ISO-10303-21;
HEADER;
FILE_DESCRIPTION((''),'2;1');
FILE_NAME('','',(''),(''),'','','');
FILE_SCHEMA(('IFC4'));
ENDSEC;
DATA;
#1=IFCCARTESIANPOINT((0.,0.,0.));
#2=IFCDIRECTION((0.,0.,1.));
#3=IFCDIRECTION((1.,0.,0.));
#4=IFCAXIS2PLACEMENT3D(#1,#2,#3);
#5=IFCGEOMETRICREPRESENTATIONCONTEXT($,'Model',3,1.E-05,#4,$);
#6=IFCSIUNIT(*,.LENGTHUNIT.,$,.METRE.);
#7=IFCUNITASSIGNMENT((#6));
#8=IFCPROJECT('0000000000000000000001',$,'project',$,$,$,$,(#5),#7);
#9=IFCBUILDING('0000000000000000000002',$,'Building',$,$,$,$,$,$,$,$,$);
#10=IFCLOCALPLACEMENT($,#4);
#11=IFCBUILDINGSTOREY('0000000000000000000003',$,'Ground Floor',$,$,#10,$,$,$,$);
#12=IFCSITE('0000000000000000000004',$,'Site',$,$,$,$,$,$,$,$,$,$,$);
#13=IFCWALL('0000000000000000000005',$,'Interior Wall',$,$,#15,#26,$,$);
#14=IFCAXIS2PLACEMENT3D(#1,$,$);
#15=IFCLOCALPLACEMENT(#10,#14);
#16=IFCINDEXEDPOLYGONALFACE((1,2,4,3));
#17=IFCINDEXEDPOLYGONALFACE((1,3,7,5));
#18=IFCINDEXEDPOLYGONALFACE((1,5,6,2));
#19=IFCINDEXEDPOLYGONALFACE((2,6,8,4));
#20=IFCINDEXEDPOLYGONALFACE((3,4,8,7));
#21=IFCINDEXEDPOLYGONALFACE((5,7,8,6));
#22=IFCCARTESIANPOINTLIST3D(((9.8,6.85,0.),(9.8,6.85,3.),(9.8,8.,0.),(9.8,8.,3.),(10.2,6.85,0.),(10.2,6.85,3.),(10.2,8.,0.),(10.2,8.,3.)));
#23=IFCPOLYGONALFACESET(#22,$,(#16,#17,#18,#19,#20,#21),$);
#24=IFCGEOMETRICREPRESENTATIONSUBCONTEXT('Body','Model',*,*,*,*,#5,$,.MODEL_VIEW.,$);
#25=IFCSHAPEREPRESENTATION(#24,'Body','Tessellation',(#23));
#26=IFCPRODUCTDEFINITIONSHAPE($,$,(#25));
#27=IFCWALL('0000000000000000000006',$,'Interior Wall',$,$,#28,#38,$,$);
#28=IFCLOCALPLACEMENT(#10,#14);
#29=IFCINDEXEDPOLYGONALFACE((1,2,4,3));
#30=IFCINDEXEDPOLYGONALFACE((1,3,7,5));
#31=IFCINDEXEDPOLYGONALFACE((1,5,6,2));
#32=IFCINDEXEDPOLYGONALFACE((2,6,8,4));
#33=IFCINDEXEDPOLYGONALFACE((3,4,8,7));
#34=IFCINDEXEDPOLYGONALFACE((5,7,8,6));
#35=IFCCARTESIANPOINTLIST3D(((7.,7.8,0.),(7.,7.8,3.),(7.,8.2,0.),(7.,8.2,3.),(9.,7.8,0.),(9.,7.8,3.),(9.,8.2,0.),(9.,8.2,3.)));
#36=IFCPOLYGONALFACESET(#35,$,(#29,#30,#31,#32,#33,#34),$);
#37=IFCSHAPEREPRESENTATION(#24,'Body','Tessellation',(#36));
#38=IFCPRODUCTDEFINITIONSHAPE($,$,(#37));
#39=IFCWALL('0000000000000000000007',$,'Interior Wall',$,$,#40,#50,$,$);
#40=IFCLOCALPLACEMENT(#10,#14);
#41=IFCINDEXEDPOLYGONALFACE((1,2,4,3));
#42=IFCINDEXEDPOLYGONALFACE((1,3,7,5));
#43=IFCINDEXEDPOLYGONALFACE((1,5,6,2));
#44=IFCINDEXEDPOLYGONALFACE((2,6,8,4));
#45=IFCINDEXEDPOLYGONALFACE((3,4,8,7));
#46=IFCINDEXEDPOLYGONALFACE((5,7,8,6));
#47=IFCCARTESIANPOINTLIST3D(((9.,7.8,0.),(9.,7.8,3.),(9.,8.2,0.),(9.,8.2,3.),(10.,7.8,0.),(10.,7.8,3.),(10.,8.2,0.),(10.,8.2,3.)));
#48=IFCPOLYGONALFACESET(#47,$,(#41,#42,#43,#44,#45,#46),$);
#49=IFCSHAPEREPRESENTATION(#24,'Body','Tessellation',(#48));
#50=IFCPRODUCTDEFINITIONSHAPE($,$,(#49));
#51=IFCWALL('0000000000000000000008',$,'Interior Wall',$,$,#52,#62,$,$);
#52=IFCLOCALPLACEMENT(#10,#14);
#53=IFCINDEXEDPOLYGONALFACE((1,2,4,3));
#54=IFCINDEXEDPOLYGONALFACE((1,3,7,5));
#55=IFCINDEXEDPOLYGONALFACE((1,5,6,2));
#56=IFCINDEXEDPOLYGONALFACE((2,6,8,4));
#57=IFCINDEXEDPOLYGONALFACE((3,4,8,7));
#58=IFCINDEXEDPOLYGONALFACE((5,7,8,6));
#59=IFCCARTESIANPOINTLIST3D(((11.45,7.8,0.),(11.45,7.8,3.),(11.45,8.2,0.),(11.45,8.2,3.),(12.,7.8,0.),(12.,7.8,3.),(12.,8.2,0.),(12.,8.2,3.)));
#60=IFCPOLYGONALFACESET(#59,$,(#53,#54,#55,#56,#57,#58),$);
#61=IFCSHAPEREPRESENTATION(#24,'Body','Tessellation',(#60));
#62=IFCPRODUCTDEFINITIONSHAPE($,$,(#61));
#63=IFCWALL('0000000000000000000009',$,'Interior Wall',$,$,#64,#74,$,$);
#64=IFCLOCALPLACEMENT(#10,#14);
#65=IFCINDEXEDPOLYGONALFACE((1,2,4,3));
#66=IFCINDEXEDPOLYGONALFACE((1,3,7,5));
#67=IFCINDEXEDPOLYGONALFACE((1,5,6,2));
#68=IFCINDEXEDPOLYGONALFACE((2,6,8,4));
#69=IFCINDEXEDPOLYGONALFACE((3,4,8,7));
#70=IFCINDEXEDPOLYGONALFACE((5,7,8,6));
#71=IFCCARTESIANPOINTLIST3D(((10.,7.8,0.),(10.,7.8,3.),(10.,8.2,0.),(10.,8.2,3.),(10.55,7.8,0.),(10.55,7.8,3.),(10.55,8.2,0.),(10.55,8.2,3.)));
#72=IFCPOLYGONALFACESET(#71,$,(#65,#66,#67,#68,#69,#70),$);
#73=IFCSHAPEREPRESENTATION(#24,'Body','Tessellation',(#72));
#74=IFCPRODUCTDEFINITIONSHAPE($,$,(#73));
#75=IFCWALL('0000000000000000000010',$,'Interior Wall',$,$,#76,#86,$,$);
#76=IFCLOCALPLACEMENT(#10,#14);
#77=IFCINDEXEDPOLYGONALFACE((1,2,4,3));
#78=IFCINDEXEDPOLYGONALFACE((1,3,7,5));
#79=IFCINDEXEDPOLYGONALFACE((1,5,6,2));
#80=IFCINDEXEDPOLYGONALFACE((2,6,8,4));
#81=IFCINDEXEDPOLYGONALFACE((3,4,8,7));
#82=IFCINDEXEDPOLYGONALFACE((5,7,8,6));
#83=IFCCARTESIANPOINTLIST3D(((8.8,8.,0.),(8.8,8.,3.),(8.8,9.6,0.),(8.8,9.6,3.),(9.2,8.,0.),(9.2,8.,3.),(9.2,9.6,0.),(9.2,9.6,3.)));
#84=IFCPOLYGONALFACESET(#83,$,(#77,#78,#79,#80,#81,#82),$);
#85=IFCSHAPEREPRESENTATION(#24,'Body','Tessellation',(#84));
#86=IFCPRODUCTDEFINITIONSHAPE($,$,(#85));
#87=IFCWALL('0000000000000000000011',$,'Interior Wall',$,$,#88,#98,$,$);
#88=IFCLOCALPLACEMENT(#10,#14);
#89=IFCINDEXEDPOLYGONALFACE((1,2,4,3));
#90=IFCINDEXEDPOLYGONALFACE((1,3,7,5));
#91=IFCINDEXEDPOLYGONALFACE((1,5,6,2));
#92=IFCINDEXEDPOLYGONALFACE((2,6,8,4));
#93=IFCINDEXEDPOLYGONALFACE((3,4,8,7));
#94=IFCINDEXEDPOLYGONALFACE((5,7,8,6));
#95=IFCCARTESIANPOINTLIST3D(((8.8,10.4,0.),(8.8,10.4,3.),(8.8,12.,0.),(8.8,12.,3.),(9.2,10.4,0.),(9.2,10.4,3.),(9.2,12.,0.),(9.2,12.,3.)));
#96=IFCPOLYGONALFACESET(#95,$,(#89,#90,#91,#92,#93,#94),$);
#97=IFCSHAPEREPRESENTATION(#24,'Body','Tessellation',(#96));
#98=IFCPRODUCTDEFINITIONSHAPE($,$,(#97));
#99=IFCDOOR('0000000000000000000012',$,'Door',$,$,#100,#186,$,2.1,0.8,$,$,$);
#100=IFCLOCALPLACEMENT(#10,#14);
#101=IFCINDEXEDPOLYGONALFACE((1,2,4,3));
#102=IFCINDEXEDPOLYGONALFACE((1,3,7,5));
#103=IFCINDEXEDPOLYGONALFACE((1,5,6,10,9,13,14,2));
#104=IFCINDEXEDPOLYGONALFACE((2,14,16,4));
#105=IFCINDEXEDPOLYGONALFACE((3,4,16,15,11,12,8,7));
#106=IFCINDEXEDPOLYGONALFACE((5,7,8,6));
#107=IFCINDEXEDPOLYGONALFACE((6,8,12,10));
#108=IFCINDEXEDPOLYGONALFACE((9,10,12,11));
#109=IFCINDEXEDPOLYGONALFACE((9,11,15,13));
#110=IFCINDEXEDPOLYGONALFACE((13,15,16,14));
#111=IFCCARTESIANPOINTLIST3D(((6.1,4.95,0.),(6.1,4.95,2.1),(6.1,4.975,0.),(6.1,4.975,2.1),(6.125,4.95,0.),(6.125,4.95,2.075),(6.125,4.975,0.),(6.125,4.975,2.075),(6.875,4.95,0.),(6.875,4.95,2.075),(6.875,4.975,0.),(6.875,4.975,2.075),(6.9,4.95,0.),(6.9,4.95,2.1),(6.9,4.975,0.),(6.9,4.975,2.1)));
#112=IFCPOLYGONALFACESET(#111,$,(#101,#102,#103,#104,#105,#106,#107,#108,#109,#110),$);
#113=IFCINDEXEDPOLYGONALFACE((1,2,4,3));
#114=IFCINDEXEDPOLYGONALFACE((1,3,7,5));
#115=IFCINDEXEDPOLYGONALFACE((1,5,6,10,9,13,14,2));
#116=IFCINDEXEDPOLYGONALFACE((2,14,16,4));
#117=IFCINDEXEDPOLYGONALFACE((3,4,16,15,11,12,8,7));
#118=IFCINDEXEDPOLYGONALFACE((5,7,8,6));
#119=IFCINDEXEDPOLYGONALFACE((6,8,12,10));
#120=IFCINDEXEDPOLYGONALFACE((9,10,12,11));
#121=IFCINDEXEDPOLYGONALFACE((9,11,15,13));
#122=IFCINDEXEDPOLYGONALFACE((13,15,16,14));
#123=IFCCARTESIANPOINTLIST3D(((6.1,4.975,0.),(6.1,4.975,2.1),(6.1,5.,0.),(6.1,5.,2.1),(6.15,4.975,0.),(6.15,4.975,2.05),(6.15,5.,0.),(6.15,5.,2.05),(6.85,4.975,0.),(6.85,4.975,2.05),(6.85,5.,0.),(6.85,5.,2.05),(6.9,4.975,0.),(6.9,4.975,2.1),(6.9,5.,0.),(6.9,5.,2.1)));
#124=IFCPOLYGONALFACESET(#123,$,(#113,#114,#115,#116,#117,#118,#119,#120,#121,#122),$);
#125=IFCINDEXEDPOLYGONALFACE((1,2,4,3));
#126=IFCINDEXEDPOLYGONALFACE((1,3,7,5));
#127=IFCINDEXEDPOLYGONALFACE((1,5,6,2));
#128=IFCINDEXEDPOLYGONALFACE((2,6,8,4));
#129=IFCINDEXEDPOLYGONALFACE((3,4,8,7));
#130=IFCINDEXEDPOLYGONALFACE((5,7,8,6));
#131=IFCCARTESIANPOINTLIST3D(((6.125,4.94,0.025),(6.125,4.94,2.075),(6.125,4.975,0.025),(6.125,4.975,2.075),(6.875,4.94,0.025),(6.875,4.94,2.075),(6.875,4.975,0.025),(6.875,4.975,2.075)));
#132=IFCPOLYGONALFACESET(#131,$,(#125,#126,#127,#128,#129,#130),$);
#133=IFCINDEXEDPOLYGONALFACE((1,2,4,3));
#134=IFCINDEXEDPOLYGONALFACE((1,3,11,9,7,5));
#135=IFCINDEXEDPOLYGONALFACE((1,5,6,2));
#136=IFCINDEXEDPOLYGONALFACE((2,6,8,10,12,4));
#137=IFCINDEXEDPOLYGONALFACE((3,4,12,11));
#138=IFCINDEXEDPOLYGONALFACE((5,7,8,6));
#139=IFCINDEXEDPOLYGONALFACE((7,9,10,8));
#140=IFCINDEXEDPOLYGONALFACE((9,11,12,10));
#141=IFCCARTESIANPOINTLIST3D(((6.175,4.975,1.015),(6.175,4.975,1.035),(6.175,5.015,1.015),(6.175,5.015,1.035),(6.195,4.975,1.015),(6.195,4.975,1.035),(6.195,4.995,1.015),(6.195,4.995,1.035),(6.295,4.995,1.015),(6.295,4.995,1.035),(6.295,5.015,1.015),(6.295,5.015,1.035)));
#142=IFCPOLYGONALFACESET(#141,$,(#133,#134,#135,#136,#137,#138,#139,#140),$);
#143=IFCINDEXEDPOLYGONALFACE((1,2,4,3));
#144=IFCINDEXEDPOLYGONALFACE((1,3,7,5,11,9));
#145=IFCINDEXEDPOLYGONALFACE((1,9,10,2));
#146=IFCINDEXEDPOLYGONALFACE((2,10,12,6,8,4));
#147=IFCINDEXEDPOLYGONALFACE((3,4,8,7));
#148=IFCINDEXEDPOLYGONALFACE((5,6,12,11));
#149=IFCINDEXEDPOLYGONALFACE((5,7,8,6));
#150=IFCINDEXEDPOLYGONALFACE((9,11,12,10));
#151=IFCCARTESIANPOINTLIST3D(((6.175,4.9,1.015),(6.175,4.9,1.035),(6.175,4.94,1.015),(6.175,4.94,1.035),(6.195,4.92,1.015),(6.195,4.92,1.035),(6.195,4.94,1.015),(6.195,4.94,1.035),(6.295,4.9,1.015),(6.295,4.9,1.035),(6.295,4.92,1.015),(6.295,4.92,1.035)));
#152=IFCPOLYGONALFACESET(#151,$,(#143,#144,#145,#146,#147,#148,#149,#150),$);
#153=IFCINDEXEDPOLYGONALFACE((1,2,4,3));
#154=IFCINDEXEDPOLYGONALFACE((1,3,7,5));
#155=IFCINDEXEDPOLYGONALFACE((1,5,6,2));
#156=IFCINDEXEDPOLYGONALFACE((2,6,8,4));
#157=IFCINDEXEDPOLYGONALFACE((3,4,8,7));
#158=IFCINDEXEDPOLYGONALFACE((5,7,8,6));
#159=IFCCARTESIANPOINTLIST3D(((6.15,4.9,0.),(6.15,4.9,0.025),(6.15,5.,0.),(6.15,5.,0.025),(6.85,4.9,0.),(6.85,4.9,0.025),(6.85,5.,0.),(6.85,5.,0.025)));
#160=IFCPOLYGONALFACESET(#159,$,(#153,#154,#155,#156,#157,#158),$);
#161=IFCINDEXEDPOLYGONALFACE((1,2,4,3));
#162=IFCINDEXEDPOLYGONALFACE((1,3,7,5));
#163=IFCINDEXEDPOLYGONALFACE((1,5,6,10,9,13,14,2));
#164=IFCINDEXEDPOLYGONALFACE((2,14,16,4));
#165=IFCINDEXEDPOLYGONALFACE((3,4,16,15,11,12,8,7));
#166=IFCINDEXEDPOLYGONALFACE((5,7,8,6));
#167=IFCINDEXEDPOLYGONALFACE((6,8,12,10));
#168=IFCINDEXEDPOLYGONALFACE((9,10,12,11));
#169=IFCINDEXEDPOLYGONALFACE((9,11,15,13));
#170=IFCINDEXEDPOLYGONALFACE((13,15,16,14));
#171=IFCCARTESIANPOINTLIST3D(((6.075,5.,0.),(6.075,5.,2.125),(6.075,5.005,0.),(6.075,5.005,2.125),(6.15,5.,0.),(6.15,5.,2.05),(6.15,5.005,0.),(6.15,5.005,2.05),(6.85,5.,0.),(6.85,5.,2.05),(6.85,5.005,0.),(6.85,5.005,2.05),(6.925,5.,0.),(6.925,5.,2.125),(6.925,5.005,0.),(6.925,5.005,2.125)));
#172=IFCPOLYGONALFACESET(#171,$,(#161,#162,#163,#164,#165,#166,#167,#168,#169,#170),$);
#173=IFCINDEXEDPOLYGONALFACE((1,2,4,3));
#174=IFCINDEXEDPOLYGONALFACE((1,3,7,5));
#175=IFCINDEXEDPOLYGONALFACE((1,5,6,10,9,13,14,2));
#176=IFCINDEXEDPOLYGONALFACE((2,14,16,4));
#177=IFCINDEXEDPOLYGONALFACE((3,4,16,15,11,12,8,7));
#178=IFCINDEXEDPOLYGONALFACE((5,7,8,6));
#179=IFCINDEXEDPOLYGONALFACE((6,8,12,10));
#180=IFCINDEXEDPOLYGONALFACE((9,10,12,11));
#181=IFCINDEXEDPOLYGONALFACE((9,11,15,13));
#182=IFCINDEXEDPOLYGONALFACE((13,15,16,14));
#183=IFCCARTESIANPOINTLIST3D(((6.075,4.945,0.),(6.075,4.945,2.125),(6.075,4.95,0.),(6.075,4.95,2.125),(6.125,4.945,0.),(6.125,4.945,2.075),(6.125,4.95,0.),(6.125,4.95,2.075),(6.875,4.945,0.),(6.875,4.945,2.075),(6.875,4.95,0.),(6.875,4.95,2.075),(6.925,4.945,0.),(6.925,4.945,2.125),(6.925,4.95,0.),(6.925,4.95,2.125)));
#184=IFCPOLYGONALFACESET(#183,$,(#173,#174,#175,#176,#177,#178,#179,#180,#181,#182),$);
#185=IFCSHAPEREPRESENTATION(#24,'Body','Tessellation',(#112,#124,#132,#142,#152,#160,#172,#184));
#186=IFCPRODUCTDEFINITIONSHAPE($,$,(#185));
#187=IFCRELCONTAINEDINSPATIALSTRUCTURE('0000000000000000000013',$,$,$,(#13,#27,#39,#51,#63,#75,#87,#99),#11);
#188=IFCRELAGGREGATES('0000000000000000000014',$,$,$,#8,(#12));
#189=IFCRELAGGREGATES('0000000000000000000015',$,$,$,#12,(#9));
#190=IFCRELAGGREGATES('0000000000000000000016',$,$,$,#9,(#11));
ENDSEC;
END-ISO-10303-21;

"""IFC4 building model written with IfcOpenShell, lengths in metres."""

from ifc_helpers import new_model, si_unit, frame, origin_with_axes, place, context, subcontext, project, spatial, line, indexed_curve, outline, extrude, element, save


model = new_model("IFC4")

# Units and contexts
model_context = context("Model", 3, precision=1e-05, world=origin_with_axes())
body_context = subcontext(model_context, "Body", "Model", "MODEL_VIEW")
ifc_project = project(units=[si_unit("LENGTHUNIT", "METRE")], contexts=[model_context])

# Site, building, storey
site = spatial("IfcSite", under=ifc_project, Name="Site")
building = spatial("IfcBuilding", under=site, Name="Building")
storey_placement = place(None, origin_with_axes())
storey = spatial("IfcBuildingStorey", under=building, at=storey_placement, Name="Ground Floor")

# Walls
for number, where, z_axis, x_axis, name in (
    (1, (10.0, 6.85, 0.0), (0.0, 0.0, 1.0), (0.0, 1.0, 0.0), "Interior Wall"),
):
    element("IfcWall", number, at=place(storey_placement, frame(where, z_axis=z_axis, x_axis=x_axis)), inside=storey, Name=name, context=body_context, shape_type="SweptSolid", body=[
        extrude(outline(indexed_curve([(0.0, 0.0), (0.0, 0.4), (1.15, 0.4), (1.15, 0.0), (0.0, 0.0)], self_intersect=False)), frame((0.0, -0.2, 0.0), z_axis=(0.0, 0.0, 1.0), x_axis=(1.0, 0.0, 0.0)), (0.0, 0.0, 1.0), 3.0),
    ])
wall_1_placement = place(storey_placement, frame((9.0, 8.0, 0.0), z_axis=(0.0, 0.0, 1.0), x_axis=(-1.0, 0.0, 0.0)))
element("IfcWall", 2, at=wall_1_placement, inside=storey, Name="Interior Wall", context=body_context, shape_type="SweptSolid", body=[
    extrude(outline(indexed_curve([(0.0, 0.0), (0.0, 0.4), (2.0, 0.4), (2.0, 0.0), (0.0, 0.0)], self_intersect=False)), frame((0.0, -0.2, 0.0), z_axis=(0.0, 0.0, 1.0), x_axis=(1.0, 0.0, 0.0)), (0.0, 0.0, 1.0), 3.0),
])
wall_2_placement = place(storey_placement, frame((10.0, 8.0, 0.0), z_axis=(0.0, 0.0, 1.0), x_axis=(-1.0, 0.0, 0.0)))
element("IfcWall", 3, at=wall_2_placement, inside=storey, Name="Interior Wall", context=body_context, shape_type="SweptSolid", body=[
    extrude(outline(indexed_curve([(0.0, 0.0), (0.0, 0.4), (1.0, 0.4), (1.0, 0.0), (0.0, 0.0)], self_intersect=False)), frame((0.0, -0.2, 0.0), z_axis=(0.0, 0.0, 1.0), x_axis=(1.0, 0.0, 0.0)), (0.0, 0.0, 1.0), 3.0),
])
for number, where, z_axis, x_axis, name in (
    (4, (12.0, 8.0, 0.0), (0.0, 0.0, 1.0), (-1.0, 0.0, 0.0), "Interior Wall"),
    (5, (10.55, 8.0, 0.0), (0.0, 0.0, 1.0), (-1.0, 0.0, 0.0), "Interior Wall"),
):
    element("IfcWall", number, at=place(storey_placement, frame(where, z_axis=z_axis, x_axis=x_axis)), inside=storey, Name=name, context=body_context, shape_type="SweptSolid", body=[
        extrude(outline(indexed_curve([(0.0, 0.0), (0.0, 0.4), (0.55, 0.4), (0.55, 0.0), (0.0, 0.0)], self_intersect=False)), frame((0.0, -0.2, 0.0), z_axis=(0.0, 0.0, 1.0), x_axis=(1.0, 0.0, 0.0)), (0.0, 0.0, 1.0), 3.0),
    ])
for number, where, z_axis, x_axis, name in (
    (6, (9.0, 8.0, 0.0), (0.0, 0.0, 1.0), (0.0, 1.0, 0.0), "Interior Wall"),
    (7, (9.0, 10.4, 0.0), (0.0, 0.0, 1.0), (0.0, 1.0, 0.0), "Interior Wall"),
):
    element("IfcWall", number, at=place(storey_placement, frame(where, z_axis=z_axis, x_axis=x_axis)), inside=storey, Name=name, context=body_context, shape_type="SweptSolid", body=[
        extrude(outline(indexed_curve([(0.0, 0.0), (0.0, 0.4), (1.6, 0.4), (1.6, 0.0), (0.0, 0.0)], self_intersect=False)), frame((0.0, -0.2, 0.0), z_axis=(0.0, 0.0, 1.0), x_axis=(1.0, 0.0, 0.0)), (0.0, 0.0, 1.0), 3.0),
    ])

# Door
door_1_placement = place(storey_placement, frame((6.9, 5.0, 0.0), z_axis=(0.0, 0.0, 1.0), x_axis=(-1.0, 0.0, 0.0)))
element("IfcDoor", 8, at=door_1_placement, inside=storey, Name="Door", OverallHeight=2.1, OverallWidth=0.8, context=body_context, shape_type="SweptSolid", body=[
    extrude(outline(indexed_curve([(0.0, 0.0), (0.0, 2.1), (0.8, 2.1), (0.8, 0.0), (0.775, 0.0), (0.775, 2.075), (0.025, 2.075), (0.025, 0.0)], segments=[line(1, 2, 3, 4, 5, 6, 7, 8, 1)])), frame((0.0, 0.025, 0.0), z_axis=(0.0, -1.0, 0.0), x_axis=(1.0, 0.0, 0.0)), (0.0, 0.0, -1.0), 0.025),
    extrude(outline(indexed_curve([(0.0, 0.0), (0.0, 2.1), (0.8, 2.1), (0.8, 0.0), (0.75, 0.0), (0.75, 2.05), (0.05, 2.05), (0.05, 0.0)], segments=[line(1, 2, 3, 4, 5, 6, 7, 8, 1)])), frame((0.0, 0.0, 0.0), z_axis=(0.0, -1.0, 0.0), x_axis=(1.0, 0.0, 0.0)), (0.0, 0.0, -1.0), 0.025),
    extrude(outline(indexed_curve([(0.0, 0.0), (0.75, 0.0), (0.75, 0.035), (0.0, 0.035)], segments=[line(1, 2, 3, 4, 1)])), frame((0.025, 0.025, 0.025), z_axis=(0.0, 0.0, 1.0), x_axis=(1.0, 0.0, 0.0)), (0.0, 0.0, 1.0), 2.05),
    extrude(outline(indexed_curve([(0.0, 0.0), (0.0, -0.04), (-0.12, -0.04), (-0.12, -0.02), (-0.02, -0.02), (-0.02, 0.0)], segments=[line(1, 2, 3, 4, 5, 6, 1)])), frame((0.725, 0.025, 1.015), z_axis=(0.0, 0.0, 1.0), x_axis=(1.0, 0.0, 0.0)), (0.0, 0.0, 1.0), 0.02),
    extrude(outline(indexed_curve([(0.0, 0.0), (0.0, 0.04), (-0.12, 0.04), (-0.12, 0.02), (-0.02, 0.02), (-0.02, 0.0)], segments=[line(1, 2, 3, 4, 5, 6, 1)])), frame((0.725, 0.06, 1.015), z_axis=(0.0, 0.0, 1.0), x_axis=(1.0, 0.0, 0.0)), (0.0, 0.0, 1.0), 0.02),
    extrude(outline(indexed_curve([(0.0, 0.0), (0.7, 0.0), (0.7, 0.1), (0.0, 0.1)], segments=[line(1, 2, 3, 4, 1)])), frame((0.05, 0.0, 0.0), z_axis=(0.0, 0.0, 1.0), x_axis=(1.0, 0.0, 0.0)), (0.0, 0.0, 1.0), 0.025),
    extrude(outline(indexed_curve([(0.0, 0.0), (0.0, 2.125), (0.85, 2.125), (0.85, 0.0), (0.775, 0.0), (0.775, 2.05), (0.075, 2.05), (0.075, 0.0)], segments=[line(1, 2, 3, 4, 5, 6, 7, 8, 1)])), frame((-0.025, -0.005, 0.0), z_axis=(0.0, -1.0, 0.0), x_axis=(1.0, 0.0, 0.0)), (0.0, 0.0, -1.0), 0.005),
    extrude(outline(indexed_curve([(0.0, 0.0), (0.0, 2.125), (0.85, 2.125), (0.85, 0.0), (0.8, 0.0), (0.8, 2.075), (0.05, 2.075), (0.05, 0.0)], segments=[line(1, 2, 3, 4, 5, 6, 7, 8, 1)])), frame((-0.025, 0.05, 0.0), z_axis=(0.0, -1.0, 0.0), x_axis=(1.0, 0.0, 0.0)), (0.0, 0.0, -1.0), 0.005),
])

save(model, "model.ifc")
